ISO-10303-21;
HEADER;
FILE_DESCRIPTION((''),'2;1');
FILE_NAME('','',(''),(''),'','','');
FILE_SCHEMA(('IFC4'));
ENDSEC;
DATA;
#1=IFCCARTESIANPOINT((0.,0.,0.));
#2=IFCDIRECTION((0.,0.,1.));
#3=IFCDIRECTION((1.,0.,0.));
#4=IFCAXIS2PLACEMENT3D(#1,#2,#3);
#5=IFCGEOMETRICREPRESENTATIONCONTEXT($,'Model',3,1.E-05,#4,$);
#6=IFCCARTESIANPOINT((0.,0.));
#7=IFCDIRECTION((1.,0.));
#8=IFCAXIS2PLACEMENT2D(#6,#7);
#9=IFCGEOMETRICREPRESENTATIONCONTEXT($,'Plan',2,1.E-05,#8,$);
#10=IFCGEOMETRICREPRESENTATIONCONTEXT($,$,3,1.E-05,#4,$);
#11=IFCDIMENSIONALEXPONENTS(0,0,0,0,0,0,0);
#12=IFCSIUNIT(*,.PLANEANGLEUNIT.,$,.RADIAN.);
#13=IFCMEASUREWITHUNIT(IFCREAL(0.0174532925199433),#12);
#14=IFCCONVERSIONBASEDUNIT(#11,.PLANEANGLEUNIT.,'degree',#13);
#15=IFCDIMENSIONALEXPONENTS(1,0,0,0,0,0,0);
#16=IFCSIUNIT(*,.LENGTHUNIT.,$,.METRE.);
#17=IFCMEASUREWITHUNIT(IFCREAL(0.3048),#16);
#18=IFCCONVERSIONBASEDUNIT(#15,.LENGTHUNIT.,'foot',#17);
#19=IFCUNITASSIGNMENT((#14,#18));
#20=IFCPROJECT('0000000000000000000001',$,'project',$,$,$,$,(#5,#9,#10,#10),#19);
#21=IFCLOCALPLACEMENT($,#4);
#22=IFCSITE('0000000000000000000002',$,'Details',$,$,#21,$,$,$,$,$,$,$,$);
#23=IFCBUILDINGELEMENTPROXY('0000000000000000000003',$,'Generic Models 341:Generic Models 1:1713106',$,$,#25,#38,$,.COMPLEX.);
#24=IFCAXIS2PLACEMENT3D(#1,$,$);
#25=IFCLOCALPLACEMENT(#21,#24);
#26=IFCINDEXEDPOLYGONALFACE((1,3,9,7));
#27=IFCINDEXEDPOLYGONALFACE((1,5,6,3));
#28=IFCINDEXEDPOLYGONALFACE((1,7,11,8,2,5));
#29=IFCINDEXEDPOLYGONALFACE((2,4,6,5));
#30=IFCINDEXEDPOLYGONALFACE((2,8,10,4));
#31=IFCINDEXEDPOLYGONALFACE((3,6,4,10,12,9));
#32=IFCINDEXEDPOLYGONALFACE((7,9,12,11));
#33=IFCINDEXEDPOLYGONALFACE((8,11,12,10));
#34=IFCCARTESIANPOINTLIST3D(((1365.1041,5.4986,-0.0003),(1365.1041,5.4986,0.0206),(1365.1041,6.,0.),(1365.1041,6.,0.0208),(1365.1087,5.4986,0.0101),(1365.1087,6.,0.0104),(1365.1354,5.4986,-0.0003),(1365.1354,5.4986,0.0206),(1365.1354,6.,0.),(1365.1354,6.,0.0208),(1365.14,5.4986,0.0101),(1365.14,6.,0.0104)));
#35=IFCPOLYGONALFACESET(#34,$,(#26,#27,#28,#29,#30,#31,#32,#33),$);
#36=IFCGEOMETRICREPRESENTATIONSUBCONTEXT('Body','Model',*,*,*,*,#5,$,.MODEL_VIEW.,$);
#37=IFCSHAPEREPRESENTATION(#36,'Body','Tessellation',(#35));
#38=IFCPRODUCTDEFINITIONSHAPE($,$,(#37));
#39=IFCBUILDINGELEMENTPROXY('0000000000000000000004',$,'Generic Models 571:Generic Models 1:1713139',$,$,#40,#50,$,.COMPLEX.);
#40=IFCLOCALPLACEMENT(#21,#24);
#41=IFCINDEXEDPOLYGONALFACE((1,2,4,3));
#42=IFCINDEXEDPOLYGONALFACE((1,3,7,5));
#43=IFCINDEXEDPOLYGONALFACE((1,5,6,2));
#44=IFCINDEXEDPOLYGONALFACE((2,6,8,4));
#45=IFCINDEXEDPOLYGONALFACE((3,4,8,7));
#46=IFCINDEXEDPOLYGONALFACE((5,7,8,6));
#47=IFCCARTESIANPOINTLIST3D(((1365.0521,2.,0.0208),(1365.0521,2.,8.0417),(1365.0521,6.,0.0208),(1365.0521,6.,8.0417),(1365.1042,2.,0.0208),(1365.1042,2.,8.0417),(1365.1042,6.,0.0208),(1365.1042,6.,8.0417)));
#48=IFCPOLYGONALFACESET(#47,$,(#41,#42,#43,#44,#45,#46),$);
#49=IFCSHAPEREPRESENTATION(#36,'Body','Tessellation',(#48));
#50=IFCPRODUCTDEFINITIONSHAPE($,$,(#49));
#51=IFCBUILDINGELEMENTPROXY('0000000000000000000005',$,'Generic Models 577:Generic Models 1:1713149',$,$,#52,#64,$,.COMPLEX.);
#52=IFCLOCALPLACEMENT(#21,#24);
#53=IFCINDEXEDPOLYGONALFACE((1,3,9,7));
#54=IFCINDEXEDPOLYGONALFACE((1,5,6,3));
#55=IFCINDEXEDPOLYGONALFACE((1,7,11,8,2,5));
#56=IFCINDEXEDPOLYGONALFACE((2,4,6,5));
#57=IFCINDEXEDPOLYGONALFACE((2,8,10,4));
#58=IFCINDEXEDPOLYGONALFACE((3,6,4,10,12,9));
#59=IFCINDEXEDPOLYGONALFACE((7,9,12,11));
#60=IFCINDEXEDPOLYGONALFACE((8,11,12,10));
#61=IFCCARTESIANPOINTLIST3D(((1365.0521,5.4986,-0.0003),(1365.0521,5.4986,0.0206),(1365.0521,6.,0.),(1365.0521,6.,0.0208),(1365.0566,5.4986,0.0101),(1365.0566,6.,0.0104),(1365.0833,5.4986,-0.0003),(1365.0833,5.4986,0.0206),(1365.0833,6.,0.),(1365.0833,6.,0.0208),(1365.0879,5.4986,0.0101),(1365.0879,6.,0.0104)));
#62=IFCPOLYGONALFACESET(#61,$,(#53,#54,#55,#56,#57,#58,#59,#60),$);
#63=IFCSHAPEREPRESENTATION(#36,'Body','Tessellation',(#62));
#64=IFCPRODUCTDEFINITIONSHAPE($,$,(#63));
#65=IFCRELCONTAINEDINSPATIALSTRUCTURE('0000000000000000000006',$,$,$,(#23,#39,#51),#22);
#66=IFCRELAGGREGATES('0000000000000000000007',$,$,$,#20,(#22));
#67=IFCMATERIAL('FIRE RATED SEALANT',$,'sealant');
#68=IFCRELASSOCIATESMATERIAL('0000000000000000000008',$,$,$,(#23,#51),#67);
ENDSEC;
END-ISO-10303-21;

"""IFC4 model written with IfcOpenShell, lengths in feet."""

from ifc_helpers import new_model, entity, si_unit, converted_unit, frame, origin_with_axes, origin_2d_with_axis, place, context, subcontext, project, spatial, polyline, line, indexed_curve, outline, extrude, material, element, save


model = new_model("IFC4")

# Units and contexts
model_context = context("Model", 3, precision=1e-05, world=origin_with_axes())
plan_context = context("Plan", 2, precision=1e-05, world=origin_2d_with_axis())
context_of_model = context(None, 3, precision=1e-05, world=origin_with_axes())
body_context = subcontext(model_context, "Body", "Model", "MODEL_VIEW")
ifc_project = project(units=[converted_unit("PLANEANGLEUNIT", "degree", entity("IfcReal", 0.0174532925199433), si_unit("PLANEANGLEUNIT", "RADIAN"), dimensions=[0, 0, 0, 0, 0, 0, 0]), converted_unit("LENGTHUNIT", "foot", entity("IfcReal", 0.3048), si_unit("LENGTHUNIT", "METRE"), dimensions=[1, 0, 0, 0, 0, 0, 0])], contexts=[model_context, plan_context, context_of_model, context_of_model])

# Site
site_placement = place(None, origin_with_axes())
site = spatial("IfcSite", under=ifc_project, at=site_placement, Name="Details")

# Building element proxies
ifc_material_1 = material(Name="FIRE RATED SEALANT", Category="sealant")
proxy_1_placement = place(site_placement, frame((1365.1041, 6.0, 0.0), z_axis=(0.0, -1.0, 0.0), x_axis=(0.0, 0.0, 1.0)))
element("IfcBuildingElementProxy", 1, at=proxy_1_placement, inside=site, material=ifc_material_1, Name="Generic Models 341:Generic Models 1:1713106", PredefinedType="COMPLEX", context=body_context, shape_type="SweptSolid", body=[
    extrude(outline(polyline([(0.0201, 0.0), (-0.0066, 0.0162), (-0.016, 0.0097), (-0.0175, -0.0016), (0.0093, -0.0178), (0.0107, -0.0065), (0.0201, 0.0)])), frame((0.0104, -0.0172, 0.0), z_axis=(0.0, 0.0, -1.0), x_axis=(0.51911, 0.854708, 0.0)), (-0.000285, -0.000479, -1.0), 0.5014),
])
proxy_2_placement = place(site_placement, frame((1365.0521, 6.0, 0.0208), z_axis=(0.0, -1.0, 0.0), x_axis=(0.0, 0.0, 1.0)))
element("IfcBuildingElementProxy", 2, at=proxy_2_placement, inside=site, Name="Generic Models 571:Generic Models 1:1713139", PredefinedType="COMPLEX", context=body_context, shape_type="SweptSolid", body=[
    extrude(outline(indexed_curve([(-4.0104, -0.026), (4.0104, -0.026), (4.0104, 0.026), (-4.0104, 0.026)], segments=[line(4, 1), line(1, 2), line(2, 3), line(3, 4)], self_intersect=False)), frame((4.0104, -0.026, 0.0), z_axis=(0.0, 0.0, -1.0), x_axis=(1.0, 0.0, 0.0)), (0.0, 0.0, -1.0), 4.0),
])
proxy_3_placement = place(site_placement, frame((1365.0521, 6.0, 0.0), z_axis=(0.0, -1.0, 0.0), x_axis=(0.0, 0.0, 1.0)))
element("IfcBuildingElementProxy", 3, at=proxy_3_placement, inside=site, material=ifc_material_1, Name="Generic Models 577:Generic Models 1:1713149", PredefinedType="COMPLEX", context=body_context, shape_type="SweptSolid", body=[
    extrude(outline(polyline([(0.0201, 0.0), (-0.0066, 0.0162), (-0.016, 0.0097), (-0.0175, -0.0016), (0.0093, -0.0178), (0.0107, -0.0065), (0.0201, 0.0)])), frame((0.0104, -0.0172, 0.0), z_axis=(0.0, 0.0, -1.0), x_axis=(0.51911, 0.854708, 0.0)), (-0.000285, -0.000479, -1.0), 0.5014),
])

save(model, "model.ifc")
